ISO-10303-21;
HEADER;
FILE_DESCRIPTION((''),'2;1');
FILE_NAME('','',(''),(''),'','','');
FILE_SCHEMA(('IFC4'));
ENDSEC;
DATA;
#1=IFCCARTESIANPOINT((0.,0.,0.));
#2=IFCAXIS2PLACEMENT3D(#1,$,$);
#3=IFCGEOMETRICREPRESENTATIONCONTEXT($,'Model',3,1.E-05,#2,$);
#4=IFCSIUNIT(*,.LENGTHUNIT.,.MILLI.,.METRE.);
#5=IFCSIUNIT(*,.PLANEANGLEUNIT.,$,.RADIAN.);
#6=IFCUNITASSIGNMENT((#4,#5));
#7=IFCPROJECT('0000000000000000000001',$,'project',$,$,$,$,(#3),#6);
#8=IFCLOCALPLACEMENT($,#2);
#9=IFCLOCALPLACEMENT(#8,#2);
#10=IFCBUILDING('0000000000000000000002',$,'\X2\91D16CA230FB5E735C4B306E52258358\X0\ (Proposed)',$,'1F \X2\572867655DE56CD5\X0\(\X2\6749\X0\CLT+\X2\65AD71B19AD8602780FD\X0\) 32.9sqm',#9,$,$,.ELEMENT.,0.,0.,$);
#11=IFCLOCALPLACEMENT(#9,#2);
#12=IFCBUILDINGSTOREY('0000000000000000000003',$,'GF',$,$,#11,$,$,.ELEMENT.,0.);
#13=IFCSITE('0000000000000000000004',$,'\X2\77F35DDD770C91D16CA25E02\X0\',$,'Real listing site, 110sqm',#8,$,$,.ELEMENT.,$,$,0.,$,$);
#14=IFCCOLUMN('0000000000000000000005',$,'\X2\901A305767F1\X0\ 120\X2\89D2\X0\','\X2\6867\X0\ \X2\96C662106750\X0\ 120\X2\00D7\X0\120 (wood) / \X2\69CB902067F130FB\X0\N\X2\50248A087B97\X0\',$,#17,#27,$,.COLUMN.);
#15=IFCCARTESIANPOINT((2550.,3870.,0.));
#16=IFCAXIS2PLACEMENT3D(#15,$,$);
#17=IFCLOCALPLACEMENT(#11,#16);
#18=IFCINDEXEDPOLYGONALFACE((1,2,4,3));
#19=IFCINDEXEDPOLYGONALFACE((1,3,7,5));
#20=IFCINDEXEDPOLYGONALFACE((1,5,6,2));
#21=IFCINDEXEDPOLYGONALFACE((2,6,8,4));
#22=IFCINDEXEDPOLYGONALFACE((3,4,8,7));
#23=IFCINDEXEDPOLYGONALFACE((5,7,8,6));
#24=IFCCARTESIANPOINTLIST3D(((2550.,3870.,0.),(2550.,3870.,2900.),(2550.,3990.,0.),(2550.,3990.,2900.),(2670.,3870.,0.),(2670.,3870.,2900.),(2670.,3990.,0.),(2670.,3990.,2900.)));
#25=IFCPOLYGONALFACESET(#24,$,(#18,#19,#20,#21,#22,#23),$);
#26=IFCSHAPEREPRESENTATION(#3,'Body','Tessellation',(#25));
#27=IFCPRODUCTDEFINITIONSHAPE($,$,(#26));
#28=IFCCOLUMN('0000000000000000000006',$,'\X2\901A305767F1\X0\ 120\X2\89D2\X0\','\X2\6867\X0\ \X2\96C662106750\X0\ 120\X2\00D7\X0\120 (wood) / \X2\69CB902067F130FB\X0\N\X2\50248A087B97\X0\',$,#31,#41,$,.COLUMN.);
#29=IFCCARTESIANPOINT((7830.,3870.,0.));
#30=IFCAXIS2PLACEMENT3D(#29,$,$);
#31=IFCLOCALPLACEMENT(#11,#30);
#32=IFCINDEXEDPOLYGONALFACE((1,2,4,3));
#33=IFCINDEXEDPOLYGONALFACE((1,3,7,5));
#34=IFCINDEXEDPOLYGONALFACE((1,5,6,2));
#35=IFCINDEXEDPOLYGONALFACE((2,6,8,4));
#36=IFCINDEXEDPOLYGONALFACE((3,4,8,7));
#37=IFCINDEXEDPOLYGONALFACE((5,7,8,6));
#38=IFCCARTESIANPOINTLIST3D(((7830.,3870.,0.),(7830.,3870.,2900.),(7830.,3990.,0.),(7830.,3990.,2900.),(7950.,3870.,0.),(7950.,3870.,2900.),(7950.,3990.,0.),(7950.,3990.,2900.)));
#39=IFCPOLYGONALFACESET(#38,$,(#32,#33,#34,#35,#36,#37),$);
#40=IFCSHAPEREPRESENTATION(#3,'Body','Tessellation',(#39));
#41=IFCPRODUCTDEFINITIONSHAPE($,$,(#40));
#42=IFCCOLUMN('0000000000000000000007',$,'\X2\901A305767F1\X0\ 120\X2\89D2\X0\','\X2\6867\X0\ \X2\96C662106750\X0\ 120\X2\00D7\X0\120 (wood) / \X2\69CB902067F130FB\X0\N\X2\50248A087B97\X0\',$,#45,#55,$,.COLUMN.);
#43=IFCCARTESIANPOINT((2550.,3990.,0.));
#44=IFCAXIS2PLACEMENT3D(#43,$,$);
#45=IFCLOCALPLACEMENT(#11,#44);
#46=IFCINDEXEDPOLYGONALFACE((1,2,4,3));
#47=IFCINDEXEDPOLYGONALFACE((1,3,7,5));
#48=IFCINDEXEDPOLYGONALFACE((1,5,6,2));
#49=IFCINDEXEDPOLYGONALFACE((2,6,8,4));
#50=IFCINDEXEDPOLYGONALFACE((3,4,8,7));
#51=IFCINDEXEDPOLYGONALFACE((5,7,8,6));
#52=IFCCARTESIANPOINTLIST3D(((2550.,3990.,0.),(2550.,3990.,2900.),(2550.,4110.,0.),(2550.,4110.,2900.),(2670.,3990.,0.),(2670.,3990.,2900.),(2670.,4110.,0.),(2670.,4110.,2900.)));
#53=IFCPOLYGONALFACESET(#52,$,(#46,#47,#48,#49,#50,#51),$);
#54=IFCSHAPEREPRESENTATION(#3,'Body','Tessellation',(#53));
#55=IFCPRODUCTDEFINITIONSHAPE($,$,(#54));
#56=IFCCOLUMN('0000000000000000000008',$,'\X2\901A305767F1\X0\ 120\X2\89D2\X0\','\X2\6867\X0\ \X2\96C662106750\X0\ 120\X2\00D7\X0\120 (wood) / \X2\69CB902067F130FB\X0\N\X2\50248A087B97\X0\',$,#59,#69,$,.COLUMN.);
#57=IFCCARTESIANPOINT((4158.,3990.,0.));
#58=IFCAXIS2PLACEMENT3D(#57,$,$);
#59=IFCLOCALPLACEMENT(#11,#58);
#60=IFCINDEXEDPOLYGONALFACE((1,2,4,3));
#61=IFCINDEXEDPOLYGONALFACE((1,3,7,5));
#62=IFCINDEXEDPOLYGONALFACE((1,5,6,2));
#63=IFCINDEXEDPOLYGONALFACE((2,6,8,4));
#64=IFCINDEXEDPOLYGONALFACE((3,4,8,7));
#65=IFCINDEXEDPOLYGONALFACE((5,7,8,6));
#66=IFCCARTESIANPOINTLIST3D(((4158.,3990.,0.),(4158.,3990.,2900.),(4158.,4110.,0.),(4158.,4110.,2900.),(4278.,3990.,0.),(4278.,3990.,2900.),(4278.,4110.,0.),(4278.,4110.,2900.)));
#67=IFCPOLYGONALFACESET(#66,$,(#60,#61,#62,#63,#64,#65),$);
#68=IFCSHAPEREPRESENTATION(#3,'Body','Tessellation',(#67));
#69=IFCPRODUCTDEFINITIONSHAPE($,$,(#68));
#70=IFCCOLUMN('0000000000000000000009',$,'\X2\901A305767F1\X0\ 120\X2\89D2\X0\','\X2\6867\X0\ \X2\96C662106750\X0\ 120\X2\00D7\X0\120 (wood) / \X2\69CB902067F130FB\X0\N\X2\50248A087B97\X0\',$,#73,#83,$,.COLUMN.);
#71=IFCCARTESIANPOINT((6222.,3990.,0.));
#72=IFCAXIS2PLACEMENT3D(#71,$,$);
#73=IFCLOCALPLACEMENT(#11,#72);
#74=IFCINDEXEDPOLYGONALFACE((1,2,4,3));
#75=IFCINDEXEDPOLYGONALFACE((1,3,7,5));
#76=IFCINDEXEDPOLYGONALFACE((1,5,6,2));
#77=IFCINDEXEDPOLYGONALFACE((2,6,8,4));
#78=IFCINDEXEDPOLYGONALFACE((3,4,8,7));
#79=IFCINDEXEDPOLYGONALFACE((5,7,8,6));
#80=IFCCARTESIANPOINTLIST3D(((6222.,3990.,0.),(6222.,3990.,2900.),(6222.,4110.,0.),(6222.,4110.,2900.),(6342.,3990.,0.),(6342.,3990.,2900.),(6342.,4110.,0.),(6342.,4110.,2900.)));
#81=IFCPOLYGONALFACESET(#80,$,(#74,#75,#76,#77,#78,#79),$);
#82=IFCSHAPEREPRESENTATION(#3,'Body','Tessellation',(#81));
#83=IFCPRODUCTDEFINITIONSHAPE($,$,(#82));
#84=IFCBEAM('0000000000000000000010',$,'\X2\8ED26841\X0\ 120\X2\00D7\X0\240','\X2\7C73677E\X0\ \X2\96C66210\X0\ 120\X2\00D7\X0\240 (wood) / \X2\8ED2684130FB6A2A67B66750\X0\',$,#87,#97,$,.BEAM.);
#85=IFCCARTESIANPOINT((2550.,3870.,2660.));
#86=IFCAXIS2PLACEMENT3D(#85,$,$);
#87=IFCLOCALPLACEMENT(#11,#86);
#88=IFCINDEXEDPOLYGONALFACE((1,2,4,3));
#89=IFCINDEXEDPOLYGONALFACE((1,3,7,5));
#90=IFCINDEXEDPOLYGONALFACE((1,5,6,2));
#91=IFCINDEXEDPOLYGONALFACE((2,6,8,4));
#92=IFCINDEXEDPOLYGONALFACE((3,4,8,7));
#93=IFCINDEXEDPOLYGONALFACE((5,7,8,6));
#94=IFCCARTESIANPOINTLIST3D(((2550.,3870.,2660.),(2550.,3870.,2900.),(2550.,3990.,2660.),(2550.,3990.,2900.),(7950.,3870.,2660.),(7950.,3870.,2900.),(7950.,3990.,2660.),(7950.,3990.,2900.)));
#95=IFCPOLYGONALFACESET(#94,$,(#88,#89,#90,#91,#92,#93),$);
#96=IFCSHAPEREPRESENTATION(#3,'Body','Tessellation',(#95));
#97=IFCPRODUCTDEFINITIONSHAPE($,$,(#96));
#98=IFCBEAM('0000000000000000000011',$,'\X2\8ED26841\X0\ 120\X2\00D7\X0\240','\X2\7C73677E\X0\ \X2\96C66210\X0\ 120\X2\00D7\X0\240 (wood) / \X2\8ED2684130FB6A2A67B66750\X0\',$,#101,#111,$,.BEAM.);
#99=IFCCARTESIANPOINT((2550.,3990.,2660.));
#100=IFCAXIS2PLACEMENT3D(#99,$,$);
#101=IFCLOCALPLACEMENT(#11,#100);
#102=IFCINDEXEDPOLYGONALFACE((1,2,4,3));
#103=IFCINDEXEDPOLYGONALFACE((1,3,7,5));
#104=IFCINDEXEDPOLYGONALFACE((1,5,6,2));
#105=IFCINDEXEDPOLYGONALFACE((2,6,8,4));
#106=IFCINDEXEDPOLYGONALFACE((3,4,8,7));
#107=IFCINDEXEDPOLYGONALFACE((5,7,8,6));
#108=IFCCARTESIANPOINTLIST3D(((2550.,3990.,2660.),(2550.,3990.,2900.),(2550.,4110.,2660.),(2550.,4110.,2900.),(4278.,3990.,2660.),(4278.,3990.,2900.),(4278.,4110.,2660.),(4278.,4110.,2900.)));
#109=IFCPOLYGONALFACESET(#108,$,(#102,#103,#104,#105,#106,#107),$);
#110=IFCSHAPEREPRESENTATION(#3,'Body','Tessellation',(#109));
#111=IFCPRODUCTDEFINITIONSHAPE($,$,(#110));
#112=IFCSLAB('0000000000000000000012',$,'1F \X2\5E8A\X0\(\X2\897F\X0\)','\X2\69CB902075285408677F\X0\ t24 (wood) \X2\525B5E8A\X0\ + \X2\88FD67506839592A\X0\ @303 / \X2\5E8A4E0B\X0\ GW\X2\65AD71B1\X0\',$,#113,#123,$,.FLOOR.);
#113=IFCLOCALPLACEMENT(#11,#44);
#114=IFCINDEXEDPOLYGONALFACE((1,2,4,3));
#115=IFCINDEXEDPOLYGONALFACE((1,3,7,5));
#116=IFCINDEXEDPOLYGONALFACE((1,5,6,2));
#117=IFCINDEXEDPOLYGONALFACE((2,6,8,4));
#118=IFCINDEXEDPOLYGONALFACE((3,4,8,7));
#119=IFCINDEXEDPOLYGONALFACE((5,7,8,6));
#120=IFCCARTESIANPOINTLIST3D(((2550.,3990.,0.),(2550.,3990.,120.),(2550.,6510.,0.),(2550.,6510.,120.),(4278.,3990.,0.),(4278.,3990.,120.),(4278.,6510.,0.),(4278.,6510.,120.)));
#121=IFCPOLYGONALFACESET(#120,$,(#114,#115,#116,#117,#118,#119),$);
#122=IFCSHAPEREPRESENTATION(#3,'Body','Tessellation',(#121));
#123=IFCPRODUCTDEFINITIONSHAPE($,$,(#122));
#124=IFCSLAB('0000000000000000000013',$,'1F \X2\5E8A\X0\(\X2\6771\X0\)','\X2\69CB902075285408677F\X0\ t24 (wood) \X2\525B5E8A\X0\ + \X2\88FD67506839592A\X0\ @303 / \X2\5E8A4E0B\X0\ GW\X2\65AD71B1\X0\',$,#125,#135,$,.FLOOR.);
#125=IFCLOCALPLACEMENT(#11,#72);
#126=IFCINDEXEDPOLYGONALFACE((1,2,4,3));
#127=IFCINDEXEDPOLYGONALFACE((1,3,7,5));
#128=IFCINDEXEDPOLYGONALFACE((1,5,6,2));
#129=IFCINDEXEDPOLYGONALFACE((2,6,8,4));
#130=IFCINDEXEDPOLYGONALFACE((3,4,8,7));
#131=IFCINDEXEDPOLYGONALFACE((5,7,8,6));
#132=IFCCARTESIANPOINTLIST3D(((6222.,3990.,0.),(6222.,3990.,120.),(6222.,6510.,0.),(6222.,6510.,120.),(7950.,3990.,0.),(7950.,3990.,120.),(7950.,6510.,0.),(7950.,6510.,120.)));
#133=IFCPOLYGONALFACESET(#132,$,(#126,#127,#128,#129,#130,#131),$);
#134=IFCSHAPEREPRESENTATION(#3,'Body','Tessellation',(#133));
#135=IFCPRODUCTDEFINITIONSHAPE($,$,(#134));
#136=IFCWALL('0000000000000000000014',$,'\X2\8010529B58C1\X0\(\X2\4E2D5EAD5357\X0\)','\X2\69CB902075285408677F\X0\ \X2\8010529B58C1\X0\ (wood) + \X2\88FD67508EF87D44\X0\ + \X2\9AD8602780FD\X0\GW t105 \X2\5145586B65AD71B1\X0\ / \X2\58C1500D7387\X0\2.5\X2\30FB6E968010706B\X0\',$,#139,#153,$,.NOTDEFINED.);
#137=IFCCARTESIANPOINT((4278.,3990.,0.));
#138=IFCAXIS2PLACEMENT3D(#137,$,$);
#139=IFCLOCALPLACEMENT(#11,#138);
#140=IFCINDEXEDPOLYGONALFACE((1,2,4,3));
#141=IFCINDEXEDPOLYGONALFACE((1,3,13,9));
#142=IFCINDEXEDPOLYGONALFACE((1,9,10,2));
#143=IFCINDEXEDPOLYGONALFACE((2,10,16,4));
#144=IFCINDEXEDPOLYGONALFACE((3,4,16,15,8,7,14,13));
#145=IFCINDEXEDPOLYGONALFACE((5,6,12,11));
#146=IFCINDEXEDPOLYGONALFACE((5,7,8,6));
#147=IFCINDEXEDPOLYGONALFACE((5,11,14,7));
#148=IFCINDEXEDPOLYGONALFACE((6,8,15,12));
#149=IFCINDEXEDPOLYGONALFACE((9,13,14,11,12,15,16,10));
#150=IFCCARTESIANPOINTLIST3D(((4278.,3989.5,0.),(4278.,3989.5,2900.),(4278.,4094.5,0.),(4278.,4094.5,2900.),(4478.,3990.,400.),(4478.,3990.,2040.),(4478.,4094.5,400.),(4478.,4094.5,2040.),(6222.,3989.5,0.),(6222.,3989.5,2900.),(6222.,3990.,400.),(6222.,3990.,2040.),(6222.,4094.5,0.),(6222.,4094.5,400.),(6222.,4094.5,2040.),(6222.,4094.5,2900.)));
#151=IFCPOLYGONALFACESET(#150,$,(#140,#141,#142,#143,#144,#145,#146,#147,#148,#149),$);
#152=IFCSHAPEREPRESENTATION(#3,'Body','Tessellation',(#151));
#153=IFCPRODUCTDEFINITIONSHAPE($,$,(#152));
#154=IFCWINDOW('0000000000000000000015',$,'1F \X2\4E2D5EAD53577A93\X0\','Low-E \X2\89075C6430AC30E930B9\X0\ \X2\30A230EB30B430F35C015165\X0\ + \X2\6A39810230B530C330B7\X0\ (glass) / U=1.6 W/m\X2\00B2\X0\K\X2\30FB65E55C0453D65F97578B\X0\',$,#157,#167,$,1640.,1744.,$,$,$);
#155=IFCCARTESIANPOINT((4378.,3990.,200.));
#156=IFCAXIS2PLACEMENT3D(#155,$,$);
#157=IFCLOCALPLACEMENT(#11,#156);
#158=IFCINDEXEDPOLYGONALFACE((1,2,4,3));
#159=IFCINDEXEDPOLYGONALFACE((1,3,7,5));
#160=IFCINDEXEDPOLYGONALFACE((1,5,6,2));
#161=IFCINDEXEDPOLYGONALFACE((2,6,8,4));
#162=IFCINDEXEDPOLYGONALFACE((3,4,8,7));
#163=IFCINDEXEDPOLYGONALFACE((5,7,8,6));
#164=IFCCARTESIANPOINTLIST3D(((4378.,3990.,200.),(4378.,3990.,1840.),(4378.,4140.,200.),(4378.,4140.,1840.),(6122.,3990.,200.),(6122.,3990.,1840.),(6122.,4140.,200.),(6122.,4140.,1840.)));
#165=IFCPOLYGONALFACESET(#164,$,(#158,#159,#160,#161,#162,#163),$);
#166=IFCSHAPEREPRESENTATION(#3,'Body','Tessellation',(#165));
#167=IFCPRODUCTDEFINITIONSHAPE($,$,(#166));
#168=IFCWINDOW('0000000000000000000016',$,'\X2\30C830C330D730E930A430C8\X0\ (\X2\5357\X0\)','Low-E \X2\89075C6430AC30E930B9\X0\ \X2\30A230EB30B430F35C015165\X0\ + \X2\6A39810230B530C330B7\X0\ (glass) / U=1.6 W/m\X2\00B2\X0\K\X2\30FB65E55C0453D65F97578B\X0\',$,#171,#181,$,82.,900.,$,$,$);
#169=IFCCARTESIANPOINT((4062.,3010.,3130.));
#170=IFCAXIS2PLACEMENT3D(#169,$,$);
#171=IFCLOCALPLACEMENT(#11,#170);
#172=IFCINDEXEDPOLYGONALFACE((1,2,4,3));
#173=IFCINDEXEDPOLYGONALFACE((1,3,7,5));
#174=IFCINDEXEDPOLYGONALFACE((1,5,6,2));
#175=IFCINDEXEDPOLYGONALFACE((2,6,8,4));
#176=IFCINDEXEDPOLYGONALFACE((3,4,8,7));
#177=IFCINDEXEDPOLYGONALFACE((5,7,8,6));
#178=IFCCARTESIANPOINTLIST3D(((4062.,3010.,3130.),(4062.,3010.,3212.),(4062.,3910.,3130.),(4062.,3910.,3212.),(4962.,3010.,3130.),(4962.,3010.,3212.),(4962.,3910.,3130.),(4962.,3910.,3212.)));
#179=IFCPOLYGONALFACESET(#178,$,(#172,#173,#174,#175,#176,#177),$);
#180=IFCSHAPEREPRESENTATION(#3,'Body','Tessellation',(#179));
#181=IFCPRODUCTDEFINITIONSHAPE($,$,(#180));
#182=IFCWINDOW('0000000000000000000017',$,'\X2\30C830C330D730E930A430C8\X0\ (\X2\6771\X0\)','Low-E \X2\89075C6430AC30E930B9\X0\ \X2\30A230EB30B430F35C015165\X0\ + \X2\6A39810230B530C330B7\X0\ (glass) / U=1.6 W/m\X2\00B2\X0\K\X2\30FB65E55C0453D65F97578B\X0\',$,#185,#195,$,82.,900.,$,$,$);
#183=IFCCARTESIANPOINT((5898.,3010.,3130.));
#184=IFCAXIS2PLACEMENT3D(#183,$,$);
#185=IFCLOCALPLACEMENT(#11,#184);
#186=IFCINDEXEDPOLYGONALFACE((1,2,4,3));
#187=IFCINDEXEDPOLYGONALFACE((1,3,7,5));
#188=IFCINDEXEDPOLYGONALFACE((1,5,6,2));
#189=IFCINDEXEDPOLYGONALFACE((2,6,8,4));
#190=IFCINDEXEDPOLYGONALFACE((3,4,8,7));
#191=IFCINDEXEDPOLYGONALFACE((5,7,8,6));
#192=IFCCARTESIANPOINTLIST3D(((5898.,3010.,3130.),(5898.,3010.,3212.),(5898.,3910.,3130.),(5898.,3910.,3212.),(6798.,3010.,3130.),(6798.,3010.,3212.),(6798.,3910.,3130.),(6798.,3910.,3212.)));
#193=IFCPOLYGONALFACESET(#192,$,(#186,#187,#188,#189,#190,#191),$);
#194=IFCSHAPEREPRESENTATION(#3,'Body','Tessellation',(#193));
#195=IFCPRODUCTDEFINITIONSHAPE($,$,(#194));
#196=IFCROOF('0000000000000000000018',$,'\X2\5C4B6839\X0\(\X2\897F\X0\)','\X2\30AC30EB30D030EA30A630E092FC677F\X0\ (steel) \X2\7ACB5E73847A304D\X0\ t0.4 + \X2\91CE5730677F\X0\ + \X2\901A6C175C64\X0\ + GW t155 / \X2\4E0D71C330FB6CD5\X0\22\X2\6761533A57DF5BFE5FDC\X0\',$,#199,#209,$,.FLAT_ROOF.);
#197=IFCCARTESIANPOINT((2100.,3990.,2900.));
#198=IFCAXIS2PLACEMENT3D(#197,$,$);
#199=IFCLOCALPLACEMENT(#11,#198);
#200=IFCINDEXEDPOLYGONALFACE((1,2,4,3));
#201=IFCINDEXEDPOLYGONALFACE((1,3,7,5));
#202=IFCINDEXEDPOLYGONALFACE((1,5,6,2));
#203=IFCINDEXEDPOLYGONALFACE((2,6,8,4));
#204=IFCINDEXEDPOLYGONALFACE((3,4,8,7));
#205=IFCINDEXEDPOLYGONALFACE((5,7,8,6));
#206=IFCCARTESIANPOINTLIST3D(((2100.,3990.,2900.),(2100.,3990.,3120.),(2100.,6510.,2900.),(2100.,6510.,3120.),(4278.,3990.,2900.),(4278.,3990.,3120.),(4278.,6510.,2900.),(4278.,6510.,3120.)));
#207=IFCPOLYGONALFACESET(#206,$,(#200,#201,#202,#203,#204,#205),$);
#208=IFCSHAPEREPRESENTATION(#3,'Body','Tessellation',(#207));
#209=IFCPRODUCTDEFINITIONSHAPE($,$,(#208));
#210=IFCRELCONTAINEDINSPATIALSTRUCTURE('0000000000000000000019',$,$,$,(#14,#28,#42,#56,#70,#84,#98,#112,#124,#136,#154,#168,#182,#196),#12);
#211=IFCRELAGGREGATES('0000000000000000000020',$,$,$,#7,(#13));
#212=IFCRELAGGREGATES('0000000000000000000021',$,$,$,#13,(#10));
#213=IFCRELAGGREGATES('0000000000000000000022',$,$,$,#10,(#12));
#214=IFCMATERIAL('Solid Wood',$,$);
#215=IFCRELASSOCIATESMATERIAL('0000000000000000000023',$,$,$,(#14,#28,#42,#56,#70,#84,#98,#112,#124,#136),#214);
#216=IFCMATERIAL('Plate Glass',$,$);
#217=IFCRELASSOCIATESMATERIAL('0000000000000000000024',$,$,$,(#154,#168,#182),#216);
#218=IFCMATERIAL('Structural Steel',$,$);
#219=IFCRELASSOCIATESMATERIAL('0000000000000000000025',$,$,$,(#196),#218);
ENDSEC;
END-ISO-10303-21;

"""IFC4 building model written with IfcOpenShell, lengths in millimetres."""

from ifc_helpers import new_model, si_unit, frame, frame_2d, origin, place, context, project, spatial, rectangle, extrude, material, element, fill, save


model = new_model("IFC4")

# Units and contexts
model_context = context("Model", 3, precision=1e-05, world=origin())
ifc_project = project(units=[si_unit("LENGTHUNIT", "METRE", prefix="MILLI"), si_unit("PLANEANGLEUNIT", "RADIAN")], contexts=[model_context])

# Site, building, storey
site_placement = place(None, origin())
site = spatial("IfcSite", under=ifc_project, at=site_placement, Name="石川県金沢市", ObjectType="Real listing site, 110sqm", CompositionType="ELEMENT", RefElevation=0.0)
building_placement = place(site_placement, origin())
building = spatial("IfcBuilding", under=site, at=building_placement, Name="金沢・平屋の別荘 (Proposed)", ObjectType="1F 在来工法(杉CLT+断熱高性能) 32.9sqm", CompositionType="ELEMENT", ElevationOfRefHeight=0.0, ElevationOfTerrain=0.0)
storey_placement = place(building_placement, origin())
storey = spatial("IfcBuildingStorey", under=building, at=storey_placement, Name="GF", CompositionType="ELEMENT", Elevation=0.0)

# Columns
ifc_material_1 = material(Name="Solid Wood")
column_1_placement = place(storey_placement, frame((2550.0, 3870.0, 0.0)))
element("IfcColumn", 1, at=column_1_placement, inside=storey, material=ifc_material_1, Name="通し柱 120角", Description="桧 集成材 120×120 (wood) / 構造柱・N値計算", PredefinedType="COLUMN", context=model_context, shape_type="SweptSolid", body=[
    extrude(rectangle(XDim=120.0, YDim=120.0, at=frame_2d((60.0, 60.0))), frame((2550.0, 3870.0, 0.0)), (0.0, 0.0, 1.0), 2900.0),
])
column_2_placement = place(storey_placement, frame((7830.0, 3870.0, 0.0)))
element("IfcColumn", 2, at=column_2_placement, inside=storey, material=ifc_material_1, Name="通し柱 120角", Description="桧 集成材 120×120 (wood) / 構造柱・N値計算", PredefinedType="COLUMN", context=model_context, shape_type="SweptSolid", body=[
    extrude(rectangle(XDim=120.0, YDim=120.0, at=frame_2d((60.0, 60.0))), frame((7830.0, 3870.0, 0.0)), (0.0, 0.0, 1.0), 2900.0),
])
column_3_placement = place(storey_placement, frame((2550.0, 3990.0, 0.0)))
element("IfcColumn", 3, at=column_3_placement, inside=storey, material=ifc_material_1, Name="通し柱 120角", Description="桧 集成材 120×120 (wood) / 構造柱・N値計算", PredefinedType="COLUMN", context=model_context, shape_type="SweptSolid", body=[
    extrude(rectangle(XDim=120.0, YDim=120.0, at=frame_2d((60.0, 60.0))), frame((2550.0, 3990.0, 0.0)), (0.0, 0.0, 1.0), 2900.0),
])
column_4_placement = place(storey_placement, frame((4158.0, 3990.0, 0.0)))
element("IfcColumn", 4, at=column_4_placement, inside=storey, material=ifc_material_1, Name="通し柱 120角", Description="桧 集成材 120×120 (wood) / 構造柱・N値計算", PredefinedType="COLUMN", context=model_context, shape_type="SweptSolid", body=[
    extrude(rectangle(XDim=120.0, YDim=120.0, at=frame_2d((60.0, 60.0))), frame((4158.0, 3990.0, 0.0)), (0.0, 0.0, 1.0), 2900.0),
])
column_5_placement = place(storey_placement, frame((6222.0, 3990.0, 0.0)))
element("IfcColumn", 5, at=column_5_placement, inside=storey, material=ifc_material_1, Name="通し柱 120角", Description="桧 集成材 120×120 (wood) / 構造柱・N値計算", PredefinedType="COLUMN", context=model_context, shape_type="SweptSolid", body=[
    extrude(rectangle(XDim=120.0, YDim=120.0, at=frame_2d((60.0, 60.0))), frame((6222.0, 3990.0, 0.0)), (0.0, 0.0, 1.0), 2900.0),
])

# Beams
beam_1_placement = place(storey_placement, frame((2550.0, 3870.0, 2660.0)))
element("IfcBeam", 6, at=beam_1_placement, inside=storey, material=ifc_material_1, Name="軒桁 120×240", Description="米松 集成 120×240 (wood) / 軒桁・横架材", PredefinedType="BEAM", context=model_context, shape_type="SweptSolid", body=[
    extrude(rectangle(XDim=5400.0, YDim=120.0, at=frame_2d((2700.0, 60.0))), frame((2550.0, 3870.0, 2660.0)), (0.0, 0.0, 1.0), 240.0),
])
beam_2_placement = place(storey_placement, frame((2550.0, 3990.0, 2660.0)))
element("IfcBeam", 7, at=beam_2_placement, inside=storey, material=ifc_material_1, Name="軒桁 120×240", Description="米松 集成 120×240 (wood) / 軒桁・横架材", PredefinedType="BEAM", context=model_context, shape_type="SweptSolid", body=[
    extrude(rectangle(XDim=1728.0, YDim=120.0, at=frame_2d((864.0, 60.0))), frame((2550.0, 3990.0, 2660.0)), (0.0, 0.0, 1.0), 240.0),
])

# Slabs
slab_1_placement = place(storey_placement, frame((2550.0, 3990.0, 0.0)))
element("IfcSlab", 8, at=slab_1_placement, inside=storey, material=ifc_material_1, Name="1F 床(西)", Description="構造用合板 t24 (wood) 剛床 + 製材根太 @303 / 床下 GW断熱", PredefinedType="FLOOR", context=model_context, shape_type="SweptSolid", body=[
    extrude(rectangle(XDim=1728.0, YDim=2520.0, at=frame_2d((864.0, 1260.0))), frame((2550.0, 3990.0, 0.0)), (0.0, 0.0, 1.0), 120.0),
])
slab_2_placement = place(storey_placement, frame((6222.0, 3990.0, 0.0)))
element("IfcSlab", 9, at=slab_2_placement, inside=storey, material=ifc_material_1, Name="1F 床(東)", Description="構造用合板 t24 (wood) 剛床 + 製材根太 @303 / 床下 GW断熱", PredefinedType="FLOOR", context=model_context, shape_type="SweptSolid", body=[
    extrude(rectangle(XDim=1728.0, YDim=2520.0, at=frame_2d((864.0, 1260.0))), frame((6222.0, 3990.0, 0.0)), (0.0, 0.0, 1.0), 120.0),
])

# Wall, opening, window
wall_1_placement = place(storey_placement, frame((4278.0, 3990.0, 0.0)))
wall_1 = element("IfcWall", 10, at=wall_1_placement, inside=storey, material=ifc_material_1, Name="耐力壁(中庭南)", Description="構造用合板 耐力壁 (wood) + 製材軸組 + 高性能GW t105 充填断熱 / 壁倍率2.5・準耐火", PredefinedType="NOTDEFINED", context=model_context, shape_type="SweptSolid", body=[
    extrude(rectangle(XDim=1944.0, YDim=105.0, at=frame_2d((972.0, 52.0))), frame((4278.0, 3990.0, 0.0)), (0.0, 0.0, 1.0), 2900.0),
])
opening_placement = place(storey_placement, frame((4378.0, 3990.0, 200.0)))
opening = element("IfcOpeningElement", 11, at=opening_placement, cuts=wall_1, PredefinedType="NOTDEFINED", context=model_context, shape_type="SweptSolid", body=[
    extrude(rectangle(XDim=1744.0, YDim=150.0, at=frame_2d((872.0, 75.0))), frame((4378.0, 3990.0, 200.0)), (0.0, 0.0, 1.0), 1640.0),
])
ifc_material_2 = material(Name="Plate Glass")
window_1_placement = place(storey_placement, frame((4378.0, 3990.0, 200.0)))
window_1 = element("IfcWindow", 12, at=window_1_placement, inside=storey, material=ifc_material_2, Name="1F 中庭南窓", Description="Low-E 複層ガラス アルゴン封入 + 樹脂サッシ (glass) / U=1.6 W/m²K・日射取得型", OverallHeight=1640.0, OverallWidth=1744.0, context=model_context, shape_type="SweptSolid", body=[
    extrude(rectangle(XDim=1744.0, YDim=150.0, at=frame_2d((872.0, 75.0))), frame((4378.0, 3990.0, 200.0)), (0.0, 0.0, 1.0), 1640.0),
])
fill(opening, window_1)

# Windows
window_2_placement = place(storey_placement, frame((4062.0, 3010.0, 3130.0)))
element("IfcWindow", 13, at=window_2_placement, inside=storey, material=ifc_material_2, Name="トップライト (南)", Description="Low-E 複層ガラス アルゴン封入 + 樹脂サッシ (glass) / U=1.6 W/m²K・日射取得型", OverallHeight=82.0, OverallWidth=900.0, context=model_context, shape_type="SweptSolid", body=[
    extrude(rectangle(XDim=900.0, YDim=900.0, at=frame_2d((450.0, 450.0))), frame((4062.0, 3010.0, 3130.0)), (0.0, 0.0, 1.0), 82.0),
])
window_3_placement = place(storey_placement, frame((5898.0, 3010.0, 3130.0)))
element("IfcWindow", 14, at=window_3_placement, inside=storey, material=ifc_material_2, Name="トップライト (東)", Description="Low-E 複層ガラス アルゴン封入 + 樹脂サッシ (glass) / U=1.6 W/m²K・日射取得型", OverallHeight=82.0, OverallWidth=900.0, context=model_context, shape_type="SweptSolid", body=[
    extrude(rectangle(XDim=900.0, YDim=900.0, at=frame_2d((450.0, 450.0))), frame((5898.0, 3010.0, 3130.0)), (0.0, 0.0, 1.0), 82.0),
])

# Roof
ifc_material_3 = material(Name="Structural Steel")
roof_1_placement = place(storey_placement, frame((2100.0, 3990.0, 2900.0)))
element("IfcRoof", 15, at=roof_1_placement, inside=storey, material=ifc_material_3, Name="屋根(西)", Description="ガルバリウム鋼板 (steel) 立平葺き t0.4 + 野地板 + 通気層 + GW t155 / 不燃・法22条区域対応", PredefinedType="FLAT_ROOF", context=model_context, shape_type="SweptSolid", body=[
    extrude(rectangle(XDim=2178.0, YDim=2520.0, at=frame_2d((1089.0, 1260.0))), frame((2100.0, 3990.0, 2900.0)), (0.0, 0.0, 1.0), 220.0),
])

save(model, "model.ifc")
